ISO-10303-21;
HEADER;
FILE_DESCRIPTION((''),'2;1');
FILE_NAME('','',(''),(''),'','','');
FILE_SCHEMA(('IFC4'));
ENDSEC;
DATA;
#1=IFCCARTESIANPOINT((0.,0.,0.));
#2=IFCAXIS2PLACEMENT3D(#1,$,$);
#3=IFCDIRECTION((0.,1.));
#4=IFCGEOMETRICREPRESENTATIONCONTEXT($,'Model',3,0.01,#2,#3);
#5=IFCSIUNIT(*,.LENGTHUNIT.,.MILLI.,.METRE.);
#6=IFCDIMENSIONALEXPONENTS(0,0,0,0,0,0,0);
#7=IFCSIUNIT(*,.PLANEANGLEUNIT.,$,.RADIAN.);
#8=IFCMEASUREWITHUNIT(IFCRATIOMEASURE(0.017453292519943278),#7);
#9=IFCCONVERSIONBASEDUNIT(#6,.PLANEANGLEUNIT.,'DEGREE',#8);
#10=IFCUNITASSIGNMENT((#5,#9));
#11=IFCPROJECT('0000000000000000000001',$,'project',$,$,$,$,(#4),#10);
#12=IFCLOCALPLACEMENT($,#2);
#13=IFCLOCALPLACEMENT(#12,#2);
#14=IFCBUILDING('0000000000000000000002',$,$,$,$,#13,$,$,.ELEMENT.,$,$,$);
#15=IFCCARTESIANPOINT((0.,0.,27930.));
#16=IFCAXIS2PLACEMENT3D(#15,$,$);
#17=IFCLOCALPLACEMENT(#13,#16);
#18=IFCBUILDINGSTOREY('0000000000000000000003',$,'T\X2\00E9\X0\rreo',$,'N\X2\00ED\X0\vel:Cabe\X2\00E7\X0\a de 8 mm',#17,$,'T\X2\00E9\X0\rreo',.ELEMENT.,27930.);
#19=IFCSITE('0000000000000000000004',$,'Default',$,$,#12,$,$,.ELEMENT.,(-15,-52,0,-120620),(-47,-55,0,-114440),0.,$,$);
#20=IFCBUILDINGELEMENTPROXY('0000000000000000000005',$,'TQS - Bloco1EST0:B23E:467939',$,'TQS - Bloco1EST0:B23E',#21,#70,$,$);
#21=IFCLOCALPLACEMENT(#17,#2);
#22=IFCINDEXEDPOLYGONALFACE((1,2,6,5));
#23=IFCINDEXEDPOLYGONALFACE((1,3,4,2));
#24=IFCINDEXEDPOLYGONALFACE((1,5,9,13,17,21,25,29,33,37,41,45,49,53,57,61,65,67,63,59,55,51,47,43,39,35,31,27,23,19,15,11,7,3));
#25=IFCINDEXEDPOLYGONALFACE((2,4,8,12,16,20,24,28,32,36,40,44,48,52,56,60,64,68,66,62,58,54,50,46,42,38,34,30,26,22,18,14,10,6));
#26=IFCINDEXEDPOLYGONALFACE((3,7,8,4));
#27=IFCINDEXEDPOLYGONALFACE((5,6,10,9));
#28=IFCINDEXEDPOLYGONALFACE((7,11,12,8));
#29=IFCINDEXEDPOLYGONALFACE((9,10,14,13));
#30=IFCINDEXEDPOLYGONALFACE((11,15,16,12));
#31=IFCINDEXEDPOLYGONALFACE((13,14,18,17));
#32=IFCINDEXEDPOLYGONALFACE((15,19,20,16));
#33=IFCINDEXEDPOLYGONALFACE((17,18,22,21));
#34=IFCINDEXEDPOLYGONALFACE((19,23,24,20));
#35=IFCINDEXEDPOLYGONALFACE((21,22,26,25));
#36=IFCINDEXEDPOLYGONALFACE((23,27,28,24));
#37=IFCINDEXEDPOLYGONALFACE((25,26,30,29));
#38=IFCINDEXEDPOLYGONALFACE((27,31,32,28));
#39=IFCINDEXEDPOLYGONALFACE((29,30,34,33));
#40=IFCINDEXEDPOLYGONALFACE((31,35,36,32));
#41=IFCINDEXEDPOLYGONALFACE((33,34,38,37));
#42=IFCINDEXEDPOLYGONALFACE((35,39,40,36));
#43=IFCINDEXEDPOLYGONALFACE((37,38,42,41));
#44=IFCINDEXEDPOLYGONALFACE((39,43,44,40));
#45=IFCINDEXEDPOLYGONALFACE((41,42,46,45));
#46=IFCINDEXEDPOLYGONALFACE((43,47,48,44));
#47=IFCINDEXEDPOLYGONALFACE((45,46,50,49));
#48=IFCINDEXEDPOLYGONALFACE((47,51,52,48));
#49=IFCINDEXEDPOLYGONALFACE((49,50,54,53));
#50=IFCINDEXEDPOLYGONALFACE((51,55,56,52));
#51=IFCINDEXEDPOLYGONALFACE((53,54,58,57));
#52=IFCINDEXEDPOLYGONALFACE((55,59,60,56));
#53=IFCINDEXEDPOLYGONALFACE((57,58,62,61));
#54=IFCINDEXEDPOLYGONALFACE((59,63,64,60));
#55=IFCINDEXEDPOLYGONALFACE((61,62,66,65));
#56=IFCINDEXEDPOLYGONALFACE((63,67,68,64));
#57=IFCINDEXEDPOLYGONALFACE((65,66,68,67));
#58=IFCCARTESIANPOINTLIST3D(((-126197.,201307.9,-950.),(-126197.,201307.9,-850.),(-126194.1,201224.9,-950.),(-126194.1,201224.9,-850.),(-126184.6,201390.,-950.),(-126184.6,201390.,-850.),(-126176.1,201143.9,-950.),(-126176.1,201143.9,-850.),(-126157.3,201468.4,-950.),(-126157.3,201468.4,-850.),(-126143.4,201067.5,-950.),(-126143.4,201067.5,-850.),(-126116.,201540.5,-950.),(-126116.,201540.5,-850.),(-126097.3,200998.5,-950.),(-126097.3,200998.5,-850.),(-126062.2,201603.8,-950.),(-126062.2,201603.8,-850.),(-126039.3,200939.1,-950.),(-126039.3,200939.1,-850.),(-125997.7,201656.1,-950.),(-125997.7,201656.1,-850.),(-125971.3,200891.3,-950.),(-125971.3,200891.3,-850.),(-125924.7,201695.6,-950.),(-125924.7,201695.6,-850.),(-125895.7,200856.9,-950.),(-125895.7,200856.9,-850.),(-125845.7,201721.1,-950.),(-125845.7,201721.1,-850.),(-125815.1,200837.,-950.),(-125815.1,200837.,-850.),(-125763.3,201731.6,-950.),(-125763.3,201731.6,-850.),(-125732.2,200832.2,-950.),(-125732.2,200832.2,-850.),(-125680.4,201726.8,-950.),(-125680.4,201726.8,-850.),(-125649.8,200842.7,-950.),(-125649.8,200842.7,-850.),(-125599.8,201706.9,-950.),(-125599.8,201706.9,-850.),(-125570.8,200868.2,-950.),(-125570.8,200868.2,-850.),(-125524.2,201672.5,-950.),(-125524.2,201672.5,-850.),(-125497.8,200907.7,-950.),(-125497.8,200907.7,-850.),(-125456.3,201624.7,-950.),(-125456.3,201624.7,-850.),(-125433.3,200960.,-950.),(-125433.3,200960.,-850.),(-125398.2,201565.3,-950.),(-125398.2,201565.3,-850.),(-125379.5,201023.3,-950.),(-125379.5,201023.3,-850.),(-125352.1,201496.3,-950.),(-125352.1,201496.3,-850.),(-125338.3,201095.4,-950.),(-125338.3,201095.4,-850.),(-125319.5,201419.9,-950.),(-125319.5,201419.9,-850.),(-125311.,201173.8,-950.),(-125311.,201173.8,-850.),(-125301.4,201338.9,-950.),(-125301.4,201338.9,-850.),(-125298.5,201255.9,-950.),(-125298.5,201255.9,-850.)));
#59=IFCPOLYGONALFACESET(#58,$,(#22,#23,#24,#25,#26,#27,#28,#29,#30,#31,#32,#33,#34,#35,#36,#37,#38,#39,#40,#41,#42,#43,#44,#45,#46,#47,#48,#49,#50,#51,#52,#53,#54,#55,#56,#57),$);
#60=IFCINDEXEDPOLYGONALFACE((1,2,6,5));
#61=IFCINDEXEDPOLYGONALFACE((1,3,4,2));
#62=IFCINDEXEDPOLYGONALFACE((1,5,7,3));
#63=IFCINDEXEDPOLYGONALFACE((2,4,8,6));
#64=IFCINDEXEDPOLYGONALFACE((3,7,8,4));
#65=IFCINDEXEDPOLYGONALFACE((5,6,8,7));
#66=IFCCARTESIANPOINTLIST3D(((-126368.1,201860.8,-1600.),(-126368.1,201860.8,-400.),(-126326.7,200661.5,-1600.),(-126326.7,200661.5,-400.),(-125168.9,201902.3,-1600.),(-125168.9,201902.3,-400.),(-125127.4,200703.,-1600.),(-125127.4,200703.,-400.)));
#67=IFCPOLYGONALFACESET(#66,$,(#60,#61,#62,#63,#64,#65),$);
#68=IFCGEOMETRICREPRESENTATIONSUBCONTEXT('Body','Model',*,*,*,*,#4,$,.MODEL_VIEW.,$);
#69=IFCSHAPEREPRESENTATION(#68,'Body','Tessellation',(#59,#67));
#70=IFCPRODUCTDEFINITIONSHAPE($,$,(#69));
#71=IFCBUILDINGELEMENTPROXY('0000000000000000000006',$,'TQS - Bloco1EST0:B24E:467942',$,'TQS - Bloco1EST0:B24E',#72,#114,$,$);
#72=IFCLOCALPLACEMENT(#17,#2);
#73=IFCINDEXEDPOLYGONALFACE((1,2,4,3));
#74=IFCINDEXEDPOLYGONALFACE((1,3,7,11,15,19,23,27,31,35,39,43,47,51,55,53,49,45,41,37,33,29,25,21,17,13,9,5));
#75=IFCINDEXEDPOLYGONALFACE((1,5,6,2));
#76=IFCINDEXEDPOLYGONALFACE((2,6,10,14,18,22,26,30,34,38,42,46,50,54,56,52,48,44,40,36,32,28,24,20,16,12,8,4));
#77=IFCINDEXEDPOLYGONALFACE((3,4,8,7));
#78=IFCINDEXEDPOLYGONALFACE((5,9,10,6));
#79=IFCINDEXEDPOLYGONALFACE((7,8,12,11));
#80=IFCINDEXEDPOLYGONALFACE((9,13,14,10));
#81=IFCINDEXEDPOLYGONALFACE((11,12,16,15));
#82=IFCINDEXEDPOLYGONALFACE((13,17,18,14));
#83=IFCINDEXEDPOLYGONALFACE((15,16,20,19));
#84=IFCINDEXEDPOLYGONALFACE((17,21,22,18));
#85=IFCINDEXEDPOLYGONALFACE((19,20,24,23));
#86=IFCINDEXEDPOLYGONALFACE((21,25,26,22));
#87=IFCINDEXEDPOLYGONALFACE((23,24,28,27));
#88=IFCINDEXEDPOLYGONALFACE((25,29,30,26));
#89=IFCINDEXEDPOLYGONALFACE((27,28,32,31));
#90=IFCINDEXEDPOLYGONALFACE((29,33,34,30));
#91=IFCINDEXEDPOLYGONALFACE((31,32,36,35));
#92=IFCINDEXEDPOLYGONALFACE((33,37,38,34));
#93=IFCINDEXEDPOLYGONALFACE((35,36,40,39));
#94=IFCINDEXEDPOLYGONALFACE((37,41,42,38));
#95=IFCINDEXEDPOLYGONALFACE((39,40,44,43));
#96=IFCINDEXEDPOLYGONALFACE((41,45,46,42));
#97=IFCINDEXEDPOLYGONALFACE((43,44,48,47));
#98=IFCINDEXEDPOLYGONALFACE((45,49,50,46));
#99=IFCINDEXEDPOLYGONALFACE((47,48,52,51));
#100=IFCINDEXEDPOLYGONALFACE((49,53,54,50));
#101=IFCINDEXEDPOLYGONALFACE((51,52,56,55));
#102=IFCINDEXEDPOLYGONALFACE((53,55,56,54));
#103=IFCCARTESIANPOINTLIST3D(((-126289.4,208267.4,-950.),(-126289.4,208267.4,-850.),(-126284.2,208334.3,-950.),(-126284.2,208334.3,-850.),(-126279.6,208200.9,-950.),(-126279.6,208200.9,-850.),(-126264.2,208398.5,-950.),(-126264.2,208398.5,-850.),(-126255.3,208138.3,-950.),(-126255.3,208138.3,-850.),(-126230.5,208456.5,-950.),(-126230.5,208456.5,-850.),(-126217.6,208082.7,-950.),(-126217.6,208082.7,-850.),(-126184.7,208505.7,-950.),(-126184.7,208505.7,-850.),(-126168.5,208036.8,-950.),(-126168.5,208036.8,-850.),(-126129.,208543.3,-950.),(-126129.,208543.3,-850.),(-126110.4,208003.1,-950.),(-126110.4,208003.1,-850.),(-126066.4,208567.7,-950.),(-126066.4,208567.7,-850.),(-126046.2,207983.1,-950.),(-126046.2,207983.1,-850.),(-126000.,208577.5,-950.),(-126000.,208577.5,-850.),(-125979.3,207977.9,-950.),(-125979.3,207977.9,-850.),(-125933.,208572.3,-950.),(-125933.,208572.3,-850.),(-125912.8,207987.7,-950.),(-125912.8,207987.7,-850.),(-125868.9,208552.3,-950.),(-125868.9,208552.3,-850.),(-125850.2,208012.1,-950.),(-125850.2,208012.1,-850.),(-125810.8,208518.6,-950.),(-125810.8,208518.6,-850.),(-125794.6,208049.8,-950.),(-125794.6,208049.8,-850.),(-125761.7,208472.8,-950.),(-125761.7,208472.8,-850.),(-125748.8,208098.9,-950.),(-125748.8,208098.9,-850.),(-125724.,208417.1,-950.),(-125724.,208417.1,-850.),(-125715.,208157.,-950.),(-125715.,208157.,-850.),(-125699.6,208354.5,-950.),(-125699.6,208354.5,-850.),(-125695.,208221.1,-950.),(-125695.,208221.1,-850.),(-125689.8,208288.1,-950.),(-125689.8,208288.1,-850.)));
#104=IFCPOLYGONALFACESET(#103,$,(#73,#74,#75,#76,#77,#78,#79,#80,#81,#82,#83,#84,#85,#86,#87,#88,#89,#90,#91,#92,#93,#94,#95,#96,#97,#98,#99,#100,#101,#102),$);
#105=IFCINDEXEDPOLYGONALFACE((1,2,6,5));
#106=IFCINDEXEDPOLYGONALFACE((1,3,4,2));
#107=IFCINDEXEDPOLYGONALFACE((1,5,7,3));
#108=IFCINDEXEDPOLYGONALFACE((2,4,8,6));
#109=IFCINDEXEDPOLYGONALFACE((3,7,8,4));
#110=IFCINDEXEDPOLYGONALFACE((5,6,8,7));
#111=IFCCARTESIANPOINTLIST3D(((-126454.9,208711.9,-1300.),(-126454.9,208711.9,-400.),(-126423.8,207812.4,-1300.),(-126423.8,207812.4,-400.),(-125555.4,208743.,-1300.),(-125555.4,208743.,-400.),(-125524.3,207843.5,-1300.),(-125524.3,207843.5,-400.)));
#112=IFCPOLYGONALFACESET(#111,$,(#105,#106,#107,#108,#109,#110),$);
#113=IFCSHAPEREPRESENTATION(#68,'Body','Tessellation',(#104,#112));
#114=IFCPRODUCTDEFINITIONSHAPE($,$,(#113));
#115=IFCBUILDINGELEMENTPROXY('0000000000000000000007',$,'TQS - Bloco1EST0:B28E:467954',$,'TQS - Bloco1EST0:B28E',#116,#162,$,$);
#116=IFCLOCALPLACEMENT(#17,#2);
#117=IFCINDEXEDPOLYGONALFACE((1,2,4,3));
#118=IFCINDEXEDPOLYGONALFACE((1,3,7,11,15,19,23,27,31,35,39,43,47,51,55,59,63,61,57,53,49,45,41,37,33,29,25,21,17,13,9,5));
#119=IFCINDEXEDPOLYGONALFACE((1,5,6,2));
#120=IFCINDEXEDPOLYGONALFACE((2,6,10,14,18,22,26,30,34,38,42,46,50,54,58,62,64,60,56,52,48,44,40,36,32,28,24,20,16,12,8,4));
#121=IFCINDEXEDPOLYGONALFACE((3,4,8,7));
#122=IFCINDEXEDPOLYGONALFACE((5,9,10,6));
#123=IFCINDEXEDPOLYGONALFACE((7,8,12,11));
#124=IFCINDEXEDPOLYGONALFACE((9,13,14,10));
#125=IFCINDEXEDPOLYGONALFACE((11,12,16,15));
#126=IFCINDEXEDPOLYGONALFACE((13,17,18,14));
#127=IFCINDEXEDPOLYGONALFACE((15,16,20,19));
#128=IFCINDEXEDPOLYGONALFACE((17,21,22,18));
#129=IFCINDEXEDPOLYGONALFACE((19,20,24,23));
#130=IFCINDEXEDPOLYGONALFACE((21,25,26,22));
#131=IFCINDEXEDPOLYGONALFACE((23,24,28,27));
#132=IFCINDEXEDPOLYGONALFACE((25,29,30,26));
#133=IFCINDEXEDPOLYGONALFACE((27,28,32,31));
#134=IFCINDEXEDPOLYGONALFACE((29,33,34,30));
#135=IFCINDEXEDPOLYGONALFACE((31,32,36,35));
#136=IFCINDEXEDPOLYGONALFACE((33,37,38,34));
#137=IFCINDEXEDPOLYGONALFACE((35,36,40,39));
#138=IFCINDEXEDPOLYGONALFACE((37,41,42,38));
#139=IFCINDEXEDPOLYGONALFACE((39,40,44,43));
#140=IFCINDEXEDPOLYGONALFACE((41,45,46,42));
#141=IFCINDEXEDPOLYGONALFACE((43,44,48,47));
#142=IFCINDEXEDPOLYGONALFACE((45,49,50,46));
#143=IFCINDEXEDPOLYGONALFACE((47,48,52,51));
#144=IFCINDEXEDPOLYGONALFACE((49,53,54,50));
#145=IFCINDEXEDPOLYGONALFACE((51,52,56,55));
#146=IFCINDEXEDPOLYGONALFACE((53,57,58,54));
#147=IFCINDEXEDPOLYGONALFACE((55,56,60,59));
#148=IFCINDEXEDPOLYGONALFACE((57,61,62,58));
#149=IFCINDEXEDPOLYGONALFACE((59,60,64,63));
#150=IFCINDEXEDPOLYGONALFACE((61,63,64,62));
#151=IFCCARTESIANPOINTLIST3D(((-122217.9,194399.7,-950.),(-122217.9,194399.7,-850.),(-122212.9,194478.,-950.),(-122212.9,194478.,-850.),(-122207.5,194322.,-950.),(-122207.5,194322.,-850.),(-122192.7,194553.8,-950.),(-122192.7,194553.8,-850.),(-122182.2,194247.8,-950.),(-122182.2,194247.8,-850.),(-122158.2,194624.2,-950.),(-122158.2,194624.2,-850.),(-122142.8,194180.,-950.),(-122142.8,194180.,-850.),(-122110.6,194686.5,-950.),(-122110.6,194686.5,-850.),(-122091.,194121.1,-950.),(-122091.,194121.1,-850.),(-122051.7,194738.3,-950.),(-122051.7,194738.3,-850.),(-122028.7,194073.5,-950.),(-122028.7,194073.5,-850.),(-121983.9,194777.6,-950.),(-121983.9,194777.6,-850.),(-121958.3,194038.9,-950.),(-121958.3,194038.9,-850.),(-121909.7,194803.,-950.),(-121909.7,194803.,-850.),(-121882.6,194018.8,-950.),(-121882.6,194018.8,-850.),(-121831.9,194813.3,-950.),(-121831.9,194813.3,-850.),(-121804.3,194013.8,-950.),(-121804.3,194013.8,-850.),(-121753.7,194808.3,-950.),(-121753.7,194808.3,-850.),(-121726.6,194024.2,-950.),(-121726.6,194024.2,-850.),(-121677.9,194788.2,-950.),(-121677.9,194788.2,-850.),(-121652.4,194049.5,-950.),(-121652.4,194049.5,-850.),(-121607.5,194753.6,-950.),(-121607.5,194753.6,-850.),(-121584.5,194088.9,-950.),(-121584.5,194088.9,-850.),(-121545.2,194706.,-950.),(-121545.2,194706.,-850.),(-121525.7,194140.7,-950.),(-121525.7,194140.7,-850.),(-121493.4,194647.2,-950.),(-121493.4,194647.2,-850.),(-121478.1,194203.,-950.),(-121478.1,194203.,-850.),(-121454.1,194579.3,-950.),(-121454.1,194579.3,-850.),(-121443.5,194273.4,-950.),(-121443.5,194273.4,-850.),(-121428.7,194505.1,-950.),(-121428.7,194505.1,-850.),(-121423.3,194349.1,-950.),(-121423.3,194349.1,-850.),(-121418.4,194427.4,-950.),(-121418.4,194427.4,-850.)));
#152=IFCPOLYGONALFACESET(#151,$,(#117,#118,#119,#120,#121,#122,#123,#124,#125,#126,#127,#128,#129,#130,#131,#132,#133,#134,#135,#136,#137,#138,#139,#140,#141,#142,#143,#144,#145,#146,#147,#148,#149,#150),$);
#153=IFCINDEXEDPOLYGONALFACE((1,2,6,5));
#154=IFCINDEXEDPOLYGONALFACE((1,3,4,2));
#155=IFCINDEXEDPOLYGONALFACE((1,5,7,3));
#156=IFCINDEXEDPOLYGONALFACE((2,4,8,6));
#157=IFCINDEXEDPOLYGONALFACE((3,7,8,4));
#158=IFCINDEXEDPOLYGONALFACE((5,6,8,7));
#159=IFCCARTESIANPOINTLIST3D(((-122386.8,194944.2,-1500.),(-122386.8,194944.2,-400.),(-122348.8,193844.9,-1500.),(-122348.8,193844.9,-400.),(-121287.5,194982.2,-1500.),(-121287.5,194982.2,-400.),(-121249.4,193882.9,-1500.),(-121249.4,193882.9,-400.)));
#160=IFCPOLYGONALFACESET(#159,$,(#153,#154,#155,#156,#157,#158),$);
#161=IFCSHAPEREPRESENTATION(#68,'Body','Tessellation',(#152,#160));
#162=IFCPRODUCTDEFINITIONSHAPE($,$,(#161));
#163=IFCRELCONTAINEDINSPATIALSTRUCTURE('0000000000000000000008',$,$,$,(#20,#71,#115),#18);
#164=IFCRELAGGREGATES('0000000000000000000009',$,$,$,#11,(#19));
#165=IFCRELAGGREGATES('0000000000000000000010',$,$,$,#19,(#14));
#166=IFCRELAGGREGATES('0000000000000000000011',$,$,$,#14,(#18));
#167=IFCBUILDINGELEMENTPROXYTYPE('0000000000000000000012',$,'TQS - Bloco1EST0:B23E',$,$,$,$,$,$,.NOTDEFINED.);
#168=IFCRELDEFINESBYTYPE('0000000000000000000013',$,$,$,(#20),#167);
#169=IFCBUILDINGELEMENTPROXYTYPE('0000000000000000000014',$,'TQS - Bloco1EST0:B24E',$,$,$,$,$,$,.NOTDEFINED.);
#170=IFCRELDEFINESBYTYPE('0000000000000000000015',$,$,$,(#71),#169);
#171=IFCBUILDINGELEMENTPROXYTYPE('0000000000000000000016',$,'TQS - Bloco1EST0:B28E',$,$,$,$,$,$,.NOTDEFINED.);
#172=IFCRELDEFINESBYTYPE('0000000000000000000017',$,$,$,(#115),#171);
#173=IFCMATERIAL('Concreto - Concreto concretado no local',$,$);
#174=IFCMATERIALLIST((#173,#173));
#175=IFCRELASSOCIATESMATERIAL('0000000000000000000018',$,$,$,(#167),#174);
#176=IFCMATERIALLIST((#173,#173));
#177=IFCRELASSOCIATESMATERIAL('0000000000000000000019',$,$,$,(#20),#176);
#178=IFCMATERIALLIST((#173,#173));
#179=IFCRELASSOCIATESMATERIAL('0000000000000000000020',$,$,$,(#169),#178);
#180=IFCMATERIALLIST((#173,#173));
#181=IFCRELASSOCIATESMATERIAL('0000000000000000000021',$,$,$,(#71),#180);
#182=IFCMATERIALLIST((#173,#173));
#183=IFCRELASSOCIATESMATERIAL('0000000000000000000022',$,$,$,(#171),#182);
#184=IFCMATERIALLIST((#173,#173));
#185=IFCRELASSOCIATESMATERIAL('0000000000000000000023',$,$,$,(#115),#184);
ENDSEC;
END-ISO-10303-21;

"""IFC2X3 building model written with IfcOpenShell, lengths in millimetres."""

from ifc_helpers import new_model, entity, si_unit, converted_unit, direction, frame, frame_2d, origin, origin_2d_with_axis, place, context, subcontext, project, spatial, rectangle, circle, extrude, source, transform, mapped, material, material_list, type_object, type_shapes, element, save


model = new_model("IFC2X3")

# Units and contexts
model_context = context("Model", 3, precision=0.01, world=origin(), true_north=direction((0.0, 1.0)))
body_context = subcontext(model_context, "Body", "Model", "MODEL_VIEW")
ifc_project = project(units=[si_unit("LENGTHUNIT", "METRE", prefix="MILLI"), converted_unit("PLANEANGLEUNIT", "DEGREE", entity("IfcRatioMeasure", 0.017453292519943278), si_unit("PLANEANGLEUNIT", "RADIAN"), dimensions=[0, 0, 0, 0, 0, 0, 0])], contexts=[model_context])

# Site, building, storey
site_placement = place(None, origin())
site = spatial("IfcSite", under=ifc_project, at=site_placement, Name="Default", CompositionType="ELEMENT", RefLatitude=(-15, -52, 0, -120620), RefLongitude=(-47, -55, 0, -114440), RefElevation=0.0)
building_placement = place(site_placement, origin())
building = spatial("IfcBuilding", under=site, at=building_placement, CompositionType="ELEMENT")
storey_placement = place(building_placement, frame((0.0, 0.0, 27930.0)))
storey = spatial("IfcBuildingStorey", under=building, at=storey_placement, Name="Térreo", ObjectType="Nível:Cabeça de 8 mm", LongName="Térreo", CompositionType="ELEMENT", Elevation=27930.0)

# Building element proxies
ifc_material_1 = material(Name="Concreto - Concreto concretado no local")
ifc_material_list_1 = material_list([ifc_material_1, ifc_material_1])
ifc_material_list_2 = material_list([ifc_material_1, ifc_material_1])
building_element_proxy_type_1 = type_object("IfcBuildingElementProxyType", Name="TQS - Bloco1EST0:B23E", PredefinedType="NOTDEFINED", material=ifc_material_list_2)
shared_shape_1 = source(origin(), body_context, "Body", "SweptSolid", [
    extrude(circle(Radius=450.0, at=frame_2d((0.0, 0.0), x_axis=(1.0, 0.0))), frame((0.0, 0.0, -550.0)), (0.0, 0.0, 1.0), 100.0),
    extrude(rectangle(XDim=1200.0, YDim=1200.0, at=origin_2d_with_axis()), frame((0.0, 0.0, -1200.0), z_axis=(0.0, 0.0, 1.0), x_axis=(-1.0, 0.0, 0.0)), (0.0, 0.0, 1.0), 1200.0),
])
type_shapes(building_element_proxy_type_1, [shared_shape_1])
proxy_1_placement = place(storey_placement, frame((-125747.8, 201281.9, -400.0), z_axis=(0.0, 0.0, 1.0), x_axis=(-0.034551, 0.999403, 0.0)))
element("IfcBuildingElementProxy", 1, at=proxy_1_placement, inside=storey, type_object=building_element_proxy_type_1, material=ifc_material_list_1, Name="TQS - Bloco1EST0:B23E:467939", ObjectType="TQS - Bloco1EST0:B23E", context=body_context, shape_type="MappedRepresentation", body=[
    mapped(shared_shape_1, transform((0.0, 0.0, 0.0), scale=1.0)),
])
ifc_material_list_3 = material_list([ifc_material_1, ifc_material_1])
ifc_material_list_4 = material_list([ifc_material_1, ifc_material_1])
building_element_proxy_type_2 = type_object("IfcBuildingElementProxyType", Name="TQS - Bloco1EST0:B24E", PredefinedType="NOTDEFINED", material=ifc_material_list_4)
shared_shape_2 = source(origin(), body_context, "Body", "SweptSolid", [
    extrude(circle(Radius=300.0, at=frame_2d((0.0, 0.0), x_axis=(1.0, 0.0))), frame((0.0, 0.0, -550.0)), (0.0, 0.0, 1.0), 100.0),
    extrude(rectangle(XDim=900.0, YDim=900.0, at=origin_2d_with_axis()), frame((0.0, 0.0, -900.0), z_axis=(0.0, 0.0, 1.0), x_axis=(-1.0, 0.0, 0.0)), (0.0, 0.0, 1.0), 900.0),
])
type_shapes(building_element_proxy_type_2, [shared_shape_2])
proxy_2_placement = place(storey_placement, frame((-125989.6, 208277.7, -400.0), z_axis=(0.0, 0.0, 1.0), x_axis=(-0.034551, 0.999403, 0.0)))
element("IfcBuildingElementProxy", 2, at=proxy_2_placement, inside=storey, type_object=building_element_proxy_type_2, material=ifc_material_list_3, Name="TQS - Bloco1EST0:B24E:467942", ObjectType="TQS - Bloco1EST0:B24E", context=body_context, shape_type="MappedRepresentation", body=[
    mapped(shared_shape_2, transform((0.0, 0.0, 0.0), scale=1.0)),
])
ifc_material_list_5 = material_list([ifc_material_1, ifc_material_1])
ifc_material_list_6 = material_list([ifc_material_1, ifc_material_1])
building_element_proxy_type_3 = type_object("IfcBuildingElementProxyType", Name="TQS - Bloco1EST0:B28E", PredefinedType="NOTDEFINED", material=ifc_material_list_6)
shared_shape_3 = source(origin(), body_context, "Body", "SweptSolid", [
    extrude(circle(Radius=400.0, at=frame_2d((0.0, 0.0), x_axis=(1.0, 0.0))), frame((0.0, 0.0, -550.0)), (0.0, 0.0, 1.0), 100.0),
    extrude(rectangle(XDim=1100.0, YDim=1100.0, at=origin_2d_with_axis()), frame((0.0, 0.0, -1100.0), z_axis=(0.0, 0.0, 1.0), x_axis=(-1.0, 0.0, 0.0)), (0.0, 0.0, 1.0), 1100.0),
])
type_shapes(building_element_proxy_type_3, [shared_shape_3])
proxy_3_placement = place(storey_placement, frame((-121818.1, 194413.6, -400.0), z_axis=(0.0, 0.0, 1.0), x_axis=(-0.034551, 0.999403, 0.0)))
element("IfcBuildingElementProxy", 3, at=proxy_3_placement, inside=storey, type_object=building_element_proxy_type_3, material=ifc_material_list_5, Name="TQS - Bloco1EST0:B28E:467954", ObjectType="TQS - Bloco1EST0:B28E", context=body_context, shape_type="MappedRepresentation", body=[
    mapped(shared_shape_3, transform((0.0, 0.0, 0.0), scale=1.0)),
])

save(model, "model.ifc")
